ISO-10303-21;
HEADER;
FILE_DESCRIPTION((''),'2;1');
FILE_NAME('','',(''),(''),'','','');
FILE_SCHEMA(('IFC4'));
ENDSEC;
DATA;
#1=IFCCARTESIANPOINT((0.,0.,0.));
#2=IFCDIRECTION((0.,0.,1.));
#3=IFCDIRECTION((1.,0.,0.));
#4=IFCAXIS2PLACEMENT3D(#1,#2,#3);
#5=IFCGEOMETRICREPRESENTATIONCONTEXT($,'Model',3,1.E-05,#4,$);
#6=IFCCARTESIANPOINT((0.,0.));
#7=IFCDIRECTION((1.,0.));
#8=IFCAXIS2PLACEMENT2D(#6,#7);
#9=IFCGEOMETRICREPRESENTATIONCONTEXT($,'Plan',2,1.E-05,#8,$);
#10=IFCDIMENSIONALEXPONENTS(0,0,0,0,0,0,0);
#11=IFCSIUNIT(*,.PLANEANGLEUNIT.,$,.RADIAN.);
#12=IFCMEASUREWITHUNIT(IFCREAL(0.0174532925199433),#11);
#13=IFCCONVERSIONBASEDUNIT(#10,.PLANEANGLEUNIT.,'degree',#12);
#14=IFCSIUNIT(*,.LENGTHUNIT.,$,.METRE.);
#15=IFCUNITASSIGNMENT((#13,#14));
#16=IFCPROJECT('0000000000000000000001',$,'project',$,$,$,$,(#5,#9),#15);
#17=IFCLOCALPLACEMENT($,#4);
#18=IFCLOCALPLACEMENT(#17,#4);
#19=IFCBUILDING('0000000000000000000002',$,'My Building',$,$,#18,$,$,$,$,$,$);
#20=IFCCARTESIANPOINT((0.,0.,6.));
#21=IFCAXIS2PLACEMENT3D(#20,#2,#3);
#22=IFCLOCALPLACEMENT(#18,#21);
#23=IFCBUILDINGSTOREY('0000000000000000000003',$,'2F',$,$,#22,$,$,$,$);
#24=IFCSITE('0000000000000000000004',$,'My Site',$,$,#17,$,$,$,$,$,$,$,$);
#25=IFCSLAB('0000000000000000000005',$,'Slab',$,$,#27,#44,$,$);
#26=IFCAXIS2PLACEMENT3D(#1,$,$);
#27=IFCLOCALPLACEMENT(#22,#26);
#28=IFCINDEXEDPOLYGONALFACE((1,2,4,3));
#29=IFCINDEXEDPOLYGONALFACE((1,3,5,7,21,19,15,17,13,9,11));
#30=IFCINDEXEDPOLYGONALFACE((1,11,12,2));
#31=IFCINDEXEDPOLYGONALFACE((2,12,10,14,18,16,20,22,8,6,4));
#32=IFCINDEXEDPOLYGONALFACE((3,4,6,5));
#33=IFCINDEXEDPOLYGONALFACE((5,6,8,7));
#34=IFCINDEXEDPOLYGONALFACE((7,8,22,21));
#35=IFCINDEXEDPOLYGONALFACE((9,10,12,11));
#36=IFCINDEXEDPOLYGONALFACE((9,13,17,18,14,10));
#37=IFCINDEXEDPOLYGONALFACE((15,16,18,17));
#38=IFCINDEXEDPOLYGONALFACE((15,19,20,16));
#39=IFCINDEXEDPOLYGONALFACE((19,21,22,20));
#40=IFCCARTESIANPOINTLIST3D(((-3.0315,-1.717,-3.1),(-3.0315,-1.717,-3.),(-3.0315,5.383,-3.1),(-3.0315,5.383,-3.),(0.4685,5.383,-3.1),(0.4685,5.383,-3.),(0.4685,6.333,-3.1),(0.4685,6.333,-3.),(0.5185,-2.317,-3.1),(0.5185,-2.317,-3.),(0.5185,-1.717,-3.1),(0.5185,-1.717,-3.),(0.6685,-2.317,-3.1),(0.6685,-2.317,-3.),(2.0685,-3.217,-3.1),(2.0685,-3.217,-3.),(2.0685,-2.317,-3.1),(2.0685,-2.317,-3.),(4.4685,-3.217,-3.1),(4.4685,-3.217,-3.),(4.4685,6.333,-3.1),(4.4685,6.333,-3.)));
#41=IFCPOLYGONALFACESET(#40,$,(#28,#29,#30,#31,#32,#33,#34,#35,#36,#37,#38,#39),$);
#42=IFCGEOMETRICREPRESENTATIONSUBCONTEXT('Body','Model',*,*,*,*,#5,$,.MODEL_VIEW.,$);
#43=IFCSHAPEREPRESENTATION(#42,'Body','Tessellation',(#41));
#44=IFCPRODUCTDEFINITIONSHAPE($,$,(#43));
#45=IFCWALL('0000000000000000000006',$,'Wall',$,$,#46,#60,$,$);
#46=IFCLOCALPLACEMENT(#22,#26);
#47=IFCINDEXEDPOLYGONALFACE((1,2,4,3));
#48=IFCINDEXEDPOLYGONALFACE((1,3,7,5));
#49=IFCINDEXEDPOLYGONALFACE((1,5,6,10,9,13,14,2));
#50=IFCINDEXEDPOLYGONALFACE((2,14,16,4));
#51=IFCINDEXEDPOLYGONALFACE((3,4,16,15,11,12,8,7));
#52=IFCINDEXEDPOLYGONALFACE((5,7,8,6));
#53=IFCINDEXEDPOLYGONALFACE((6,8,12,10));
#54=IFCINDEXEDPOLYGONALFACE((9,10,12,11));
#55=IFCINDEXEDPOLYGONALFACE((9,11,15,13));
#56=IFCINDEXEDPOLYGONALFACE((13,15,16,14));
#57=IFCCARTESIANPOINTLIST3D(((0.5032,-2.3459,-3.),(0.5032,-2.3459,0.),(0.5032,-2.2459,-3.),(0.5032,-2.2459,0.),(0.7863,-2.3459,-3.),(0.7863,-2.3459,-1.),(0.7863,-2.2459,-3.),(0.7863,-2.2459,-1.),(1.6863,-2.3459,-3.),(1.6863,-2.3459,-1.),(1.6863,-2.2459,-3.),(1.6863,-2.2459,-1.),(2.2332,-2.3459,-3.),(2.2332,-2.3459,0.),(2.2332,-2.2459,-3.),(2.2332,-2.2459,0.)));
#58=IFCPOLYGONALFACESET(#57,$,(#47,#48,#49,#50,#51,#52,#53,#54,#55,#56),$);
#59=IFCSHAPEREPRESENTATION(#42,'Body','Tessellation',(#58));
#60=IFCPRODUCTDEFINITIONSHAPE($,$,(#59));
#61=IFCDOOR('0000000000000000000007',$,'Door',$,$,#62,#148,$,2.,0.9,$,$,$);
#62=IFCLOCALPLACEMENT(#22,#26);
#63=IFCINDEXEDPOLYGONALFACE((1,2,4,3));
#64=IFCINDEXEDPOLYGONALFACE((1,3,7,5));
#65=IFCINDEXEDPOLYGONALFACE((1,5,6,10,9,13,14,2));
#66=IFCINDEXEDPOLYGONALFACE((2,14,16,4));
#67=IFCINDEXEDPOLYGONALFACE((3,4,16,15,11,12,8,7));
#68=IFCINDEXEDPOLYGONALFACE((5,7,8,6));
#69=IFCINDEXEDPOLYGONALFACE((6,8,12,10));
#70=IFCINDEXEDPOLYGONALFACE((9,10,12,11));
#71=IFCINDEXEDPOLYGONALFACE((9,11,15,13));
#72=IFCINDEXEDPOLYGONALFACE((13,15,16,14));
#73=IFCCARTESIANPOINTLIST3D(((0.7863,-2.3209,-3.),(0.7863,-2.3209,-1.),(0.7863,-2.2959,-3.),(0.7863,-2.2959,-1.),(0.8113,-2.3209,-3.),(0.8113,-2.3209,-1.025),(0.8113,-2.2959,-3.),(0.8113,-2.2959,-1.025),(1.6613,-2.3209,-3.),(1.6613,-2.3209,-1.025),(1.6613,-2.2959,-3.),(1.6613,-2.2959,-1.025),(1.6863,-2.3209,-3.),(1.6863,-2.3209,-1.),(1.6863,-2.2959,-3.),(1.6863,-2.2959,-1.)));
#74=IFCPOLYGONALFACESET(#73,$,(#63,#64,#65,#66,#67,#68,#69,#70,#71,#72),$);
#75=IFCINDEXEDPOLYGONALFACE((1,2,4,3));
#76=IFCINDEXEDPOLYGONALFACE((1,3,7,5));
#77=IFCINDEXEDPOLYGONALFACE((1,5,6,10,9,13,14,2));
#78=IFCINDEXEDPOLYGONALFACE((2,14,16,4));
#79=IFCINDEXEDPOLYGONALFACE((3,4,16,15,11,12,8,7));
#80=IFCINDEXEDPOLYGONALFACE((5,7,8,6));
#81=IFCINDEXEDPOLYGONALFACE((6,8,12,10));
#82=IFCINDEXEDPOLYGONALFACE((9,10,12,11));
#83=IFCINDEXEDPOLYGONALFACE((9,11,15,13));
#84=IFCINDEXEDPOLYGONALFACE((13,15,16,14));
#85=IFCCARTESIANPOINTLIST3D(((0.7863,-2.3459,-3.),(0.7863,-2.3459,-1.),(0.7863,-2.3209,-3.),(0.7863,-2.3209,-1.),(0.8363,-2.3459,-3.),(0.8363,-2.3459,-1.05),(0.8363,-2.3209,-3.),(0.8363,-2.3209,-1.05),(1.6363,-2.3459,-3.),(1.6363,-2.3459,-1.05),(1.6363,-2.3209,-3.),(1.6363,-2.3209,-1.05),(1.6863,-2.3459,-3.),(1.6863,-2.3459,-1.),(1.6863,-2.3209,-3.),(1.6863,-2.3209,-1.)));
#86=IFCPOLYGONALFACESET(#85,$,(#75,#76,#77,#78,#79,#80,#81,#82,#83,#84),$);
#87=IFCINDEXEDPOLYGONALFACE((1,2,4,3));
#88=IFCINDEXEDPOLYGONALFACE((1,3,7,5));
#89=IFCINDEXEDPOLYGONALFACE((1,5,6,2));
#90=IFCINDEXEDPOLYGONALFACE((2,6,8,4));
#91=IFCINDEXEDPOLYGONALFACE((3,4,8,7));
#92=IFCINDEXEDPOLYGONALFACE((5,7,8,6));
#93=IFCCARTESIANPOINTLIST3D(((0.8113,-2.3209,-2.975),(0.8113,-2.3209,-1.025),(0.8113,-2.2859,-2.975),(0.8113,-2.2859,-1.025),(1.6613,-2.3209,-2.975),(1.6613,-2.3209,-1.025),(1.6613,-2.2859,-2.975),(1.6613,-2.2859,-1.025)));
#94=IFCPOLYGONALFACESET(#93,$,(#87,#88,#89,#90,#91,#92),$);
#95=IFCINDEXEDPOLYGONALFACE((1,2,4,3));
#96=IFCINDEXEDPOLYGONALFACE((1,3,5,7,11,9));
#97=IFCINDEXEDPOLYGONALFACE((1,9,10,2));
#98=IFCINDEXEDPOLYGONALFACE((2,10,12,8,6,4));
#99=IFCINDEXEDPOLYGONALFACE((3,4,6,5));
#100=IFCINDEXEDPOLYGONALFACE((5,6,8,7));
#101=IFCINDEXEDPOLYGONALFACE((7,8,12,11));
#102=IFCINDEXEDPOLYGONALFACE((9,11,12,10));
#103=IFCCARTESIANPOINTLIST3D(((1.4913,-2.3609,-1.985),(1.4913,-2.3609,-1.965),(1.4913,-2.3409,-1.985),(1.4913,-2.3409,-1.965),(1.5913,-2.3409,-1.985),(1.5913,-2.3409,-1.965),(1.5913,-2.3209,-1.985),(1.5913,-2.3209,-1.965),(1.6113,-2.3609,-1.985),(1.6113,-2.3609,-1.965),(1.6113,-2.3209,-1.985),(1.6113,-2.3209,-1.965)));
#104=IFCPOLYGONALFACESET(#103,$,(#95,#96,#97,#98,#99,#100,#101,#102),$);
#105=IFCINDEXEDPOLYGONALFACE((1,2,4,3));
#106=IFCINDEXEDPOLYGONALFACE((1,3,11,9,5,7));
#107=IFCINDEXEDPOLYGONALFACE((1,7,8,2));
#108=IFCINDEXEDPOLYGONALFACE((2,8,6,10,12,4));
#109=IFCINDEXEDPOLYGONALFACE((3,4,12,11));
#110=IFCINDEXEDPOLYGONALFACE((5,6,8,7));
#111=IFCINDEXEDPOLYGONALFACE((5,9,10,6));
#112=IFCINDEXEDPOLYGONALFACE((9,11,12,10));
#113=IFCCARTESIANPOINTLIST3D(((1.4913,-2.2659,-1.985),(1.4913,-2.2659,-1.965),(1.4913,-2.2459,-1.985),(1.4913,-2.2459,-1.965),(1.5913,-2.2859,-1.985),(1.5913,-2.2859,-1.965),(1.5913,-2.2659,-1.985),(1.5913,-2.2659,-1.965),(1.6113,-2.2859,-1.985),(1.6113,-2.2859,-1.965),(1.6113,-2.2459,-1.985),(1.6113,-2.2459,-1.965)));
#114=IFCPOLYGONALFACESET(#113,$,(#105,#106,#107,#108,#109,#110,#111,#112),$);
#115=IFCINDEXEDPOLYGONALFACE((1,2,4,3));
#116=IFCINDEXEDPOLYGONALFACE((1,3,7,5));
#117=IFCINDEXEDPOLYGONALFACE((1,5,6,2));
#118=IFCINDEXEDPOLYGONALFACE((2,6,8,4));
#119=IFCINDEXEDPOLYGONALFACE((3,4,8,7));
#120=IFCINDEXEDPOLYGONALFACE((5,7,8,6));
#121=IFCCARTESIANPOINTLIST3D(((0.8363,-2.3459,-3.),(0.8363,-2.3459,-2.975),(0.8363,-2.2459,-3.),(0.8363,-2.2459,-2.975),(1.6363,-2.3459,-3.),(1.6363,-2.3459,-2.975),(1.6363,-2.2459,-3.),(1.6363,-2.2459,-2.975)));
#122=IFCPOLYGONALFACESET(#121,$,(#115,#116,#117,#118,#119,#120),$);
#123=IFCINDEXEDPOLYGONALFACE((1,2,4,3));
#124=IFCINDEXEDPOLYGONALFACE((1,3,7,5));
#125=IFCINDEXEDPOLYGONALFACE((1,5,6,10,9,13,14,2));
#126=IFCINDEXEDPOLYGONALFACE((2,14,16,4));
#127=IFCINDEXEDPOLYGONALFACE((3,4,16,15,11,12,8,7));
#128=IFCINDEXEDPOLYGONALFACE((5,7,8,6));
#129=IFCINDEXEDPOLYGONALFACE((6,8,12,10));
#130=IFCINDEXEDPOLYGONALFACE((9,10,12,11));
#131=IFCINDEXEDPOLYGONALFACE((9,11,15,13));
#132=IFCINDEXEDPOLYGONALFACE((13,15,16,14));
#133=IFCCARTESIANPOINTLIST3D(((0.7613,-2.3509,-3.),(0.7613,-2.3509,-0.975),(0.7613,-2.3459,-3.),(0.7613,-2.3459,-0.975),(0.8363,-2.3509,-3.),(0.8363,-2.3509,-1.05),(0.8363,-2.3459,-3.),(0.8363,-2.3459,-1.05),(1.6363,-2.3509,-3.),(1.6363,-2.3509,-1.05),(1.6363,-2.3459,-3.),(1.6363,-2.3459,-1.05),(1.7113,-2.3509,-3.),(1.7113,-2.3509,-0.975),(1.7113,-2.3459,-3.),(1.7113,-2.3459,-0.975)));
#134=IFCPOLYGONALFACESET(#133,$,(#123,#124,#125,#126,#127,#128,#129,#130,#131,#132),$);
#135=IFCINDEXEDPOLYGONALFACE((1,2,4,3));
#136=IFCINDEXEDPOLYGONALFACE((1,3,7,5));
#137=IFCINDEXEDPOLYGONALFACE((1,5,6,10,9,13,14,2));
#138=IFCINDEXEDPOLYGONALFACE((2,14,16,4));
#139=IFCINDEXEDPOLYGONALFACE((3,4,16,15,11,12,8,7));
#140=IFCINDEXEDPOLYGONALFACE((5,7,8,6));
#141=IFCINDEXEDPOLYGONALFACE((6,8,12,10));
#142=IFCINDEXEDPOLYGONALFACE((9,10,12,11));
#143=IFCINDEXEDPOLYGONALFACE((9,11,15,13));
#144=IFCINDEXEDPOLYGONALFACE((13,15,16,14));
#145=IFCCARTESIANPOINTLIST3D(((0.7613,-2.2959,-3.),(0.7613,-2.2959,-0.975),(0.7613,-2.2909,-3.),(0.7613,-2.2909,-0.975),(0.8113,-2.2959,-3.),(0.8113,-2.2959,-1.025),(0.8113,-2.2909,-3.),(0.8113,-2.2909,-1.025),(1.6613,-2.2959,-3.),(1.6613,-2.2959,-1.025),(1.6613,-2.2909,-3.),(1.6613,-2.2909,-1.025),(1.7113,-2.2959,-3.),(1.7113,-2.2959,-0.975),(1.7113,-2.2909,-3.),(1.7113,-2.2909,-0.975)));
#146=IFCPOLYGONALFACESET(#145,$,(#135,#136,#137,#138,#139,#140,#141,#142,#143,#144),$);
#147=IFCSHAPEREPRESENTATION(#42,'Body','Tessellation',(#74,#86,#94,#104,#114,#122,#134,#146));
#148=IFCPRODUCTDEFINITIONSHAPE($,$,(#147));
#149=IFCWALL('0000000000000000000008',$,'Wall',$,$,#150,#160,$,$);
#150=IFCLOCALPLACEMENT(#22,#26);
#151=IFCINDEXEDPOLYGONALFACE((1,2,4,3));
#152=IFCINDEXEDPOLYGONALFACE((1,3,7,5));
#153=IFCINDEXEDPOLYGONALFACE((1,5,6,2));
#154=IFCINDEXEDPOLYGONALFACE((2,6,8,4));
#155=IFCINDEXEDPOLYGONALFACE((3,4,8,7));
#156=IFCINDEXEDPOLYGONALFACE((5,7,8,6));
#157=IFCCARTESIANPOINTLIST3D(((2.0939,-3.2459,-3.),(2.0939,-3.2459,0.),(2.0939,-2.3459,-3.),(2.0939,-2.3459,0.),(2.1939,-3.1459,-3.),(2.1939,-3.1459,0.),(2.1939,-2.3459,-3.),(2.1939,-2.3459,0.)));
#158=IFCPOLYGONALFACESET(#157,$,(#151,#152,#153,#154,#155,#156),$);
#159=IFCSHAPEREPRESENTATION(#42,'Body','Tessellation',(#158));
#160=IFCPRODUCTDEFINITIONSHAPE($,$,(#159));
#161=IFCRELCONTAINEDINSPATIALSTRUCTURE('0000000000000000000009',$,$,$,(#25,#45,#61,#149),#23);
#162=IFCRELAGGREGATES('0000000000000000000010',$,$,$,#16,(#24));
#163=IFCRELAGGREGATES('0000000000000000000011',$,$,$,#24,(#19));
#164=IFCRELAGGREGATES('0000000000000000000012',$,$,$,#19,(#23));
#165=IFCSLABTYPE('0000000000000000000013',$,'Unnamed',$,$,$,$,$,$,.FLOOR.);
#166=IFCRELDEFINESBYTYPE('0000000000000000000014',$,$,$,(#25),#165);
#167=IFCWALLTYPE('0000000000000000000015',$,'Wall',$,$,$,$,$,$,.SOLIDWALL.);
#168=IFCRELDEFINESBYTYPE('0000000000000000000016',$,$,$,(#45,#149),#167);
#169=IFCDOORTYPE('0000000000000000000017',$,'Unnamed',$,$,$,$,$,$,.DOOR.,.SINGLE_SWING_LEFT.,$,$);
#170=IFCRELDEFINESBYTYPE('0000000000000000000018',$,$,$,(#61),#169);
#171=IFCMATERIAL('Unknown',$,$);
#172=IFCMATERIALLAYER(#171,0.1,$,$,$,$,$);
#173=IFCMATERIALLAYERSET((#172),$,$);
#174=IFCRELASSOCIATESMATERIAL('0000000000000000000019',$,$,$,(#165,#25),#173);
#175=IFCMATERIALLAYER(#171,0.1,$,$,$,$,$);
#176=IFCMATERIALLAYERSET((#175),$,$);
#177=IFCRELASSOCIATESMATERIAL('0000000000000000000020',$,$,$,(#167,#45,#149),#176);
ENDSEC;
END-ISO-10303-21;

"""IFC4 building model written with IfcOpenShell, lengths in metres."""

from ifc_helpers import new_model, entity, si_unit, converted_unit, frame, origin_with_axes, origin_2d_with_axis, place, context, subcontext, project, spatial, line, indexed_curve, outline, extrude, shape, source, transform, mapped, material, layer, layer_set, layer_usage, type_object, type_shapes, element, fill, save


model = new_model("IFC4")

# Units and contexts
model_context = context("Model", 3, precision=1e-05, world=origin_with_axes())
plan_context = context("Plan", 2, precision=1e-05, world=origin_2d_with_axis())
body_context_1 = subcontext(model_context, "Body", "Model", "MODEL_VIEW")
body_context_2 = subcontext(plan_context, "Body", "Plan", "PLAN_VIEW")
ifc_project = project(units=[converted_unit("PLANEANGLEUNIT", "degree", entity("IfcReal", 0.0174532925199433), si_unit("PLANEANGLEUNIT", "RADIAN"), dimensions=[0, 0, 0, 0, 0, 0, 0]), si_unit("LENGTHUNIT", "METRE")], contexts=[model_context, plan_context])

# Site, building, storey
site_placement = place(None, origin_with_axes())
site = spatial("IfcSite", under=ifc_project, at=site_placement, Name="My Site")
building_placement = place(site_placement, origin_with_axes())
building = spatial("IfcBuilding", under=site, at=building_placement, Name="My Building")
storey_placement = place(building_placement, frame((0.0, 0.0, 6.0), z_axis=(0.0, 0.0, 1.0), x_axis=(1.0, 0.0, 0.0)))
storey = spatial("IfcBuildingStorey", under=building, at=storey_placement, Name="2F")

# Slab
ifc_material = material(Name="Unknown")
ifc_layer_1 = layer(ifc_material, 0.1)
ifc_layer_set_1 = layer_set([ifc_layer_1])
ifc_layer_usage_1 = layer_usage(ifc_layer_set_1, "AXIS3", "POSITIVE", -0.1)
slab_type = type_object("IfcSlabType", Name="Unnamed", PredefinedType="FLOOR", material=ifc_layer_set_1)
slab_placement = place(storey_placement, frame((0.6685, -2.317, -3.0), z_axis=(0.0, 0.0, 1.0), x_axis=(1.0, 0.0, 0.0)))
element("IfcSlab", 1, at=slab_placement, inside=storey, type_object=slab_type, material=ifc_layer_usage_1, Name="Slab", context=body_context_1, shape_type="SweptSolid", body=[
    extrude(outline(indexed_curve([(0.0, 0.0), (1.4, 0.0), (1.4, -0.9), (3.8, -0.9), (3.8, 8.65), (-0.2, 8.65), (-0.2, 7.7), (-3.7, 7.7), (-3.7, 0.6), (-0.15, 0.6), (-0.15, 0.0), (0.0, 0.0)])), frame((0.0, 0.0, -0.1), z_axis=(0.0, 0.0, 1.0), x_axis=(1.0, 0.0, 0.0)), (0.0, 0.0, 1.0), 0.1),
])

# Wall, opening, door
ifc_layer_2 = layer(ifc_material, 0.1)
ifc_layer_set_2 = layer_set([ifc_layer_2])
ifc_layer_usage_2 = layer_usage(ifc_layer_set_2, "AXIS2", "POSITIVE", 0.0)
wall_type = type_object("IfcWallType", Name="Wall", PredefinedType="SOLIDWALL", material=ifc_layer_set_2)
wall_1_placement = place(storey_placement, frame((0.5032, -2.3459, -3.0), z_axis=(0.0, 0.0, 1.0), x_axis=(1.0, 0.0, 0.0)))
wall_1 = element("IfcWall", 2, at=wall_1_placement, inside=storey, type_object=wall_type, material=ifc_layer_usage_2, Name="Wall", context=body_context_1, shape_type="SweptSolid", body=[
    extrude(outline(indexed_curve([(0.0, 0.0), (0.0, 0.1), (1.73, 0.1), (1.73, 0.0)], segments=[line(1, 2, 3, 4, 1)])), origin_with_axes(), (0.0, 0.0, 1.0), 3.0),
])
shared_shape_1 = source(origin_with_axes(), body_context_1, "Body", "SweptSolid", [
    extrude(outline(indexed_curve([(0.0, 0.0), (0.9, 0.0), (0.9, 2.0), (0.0, 2.0)], segments=[line(1, 2, 3, 4, 1)])), frame((0.0, -0.6, 0.0), z_axis=(0.0, -1.0, 0.0), x_axis=(1.0, 0.0, 0.0)), (0.0, 0.0, -1.0), 1.2),
])
opening_1_placement = place(wall_1_placement, frame((0.2831, 0.0, 0.0), z_axis=(0.0, 0.0, 1.0), x_axis=(1.0, 0.0, 0.0)))
opening_1 = element("IfcOpeningElement", 3, at=opening_1_placement, cuts=wall_1, PredefinedType="OPENING", context=body_context_1, shape_type="MappedRepresentation", body=[
    mapped(shared_shape_1, transform((0.0, 0.0, 0.0), x_axis=(1.0, 0.0, 0.0), y_axis=(0.0, 1.0, 0.0), z_axis=(0.0, 0.0, 1.0), scale=1.0)),
])
door_type = type_object("IfcDoorType", Name="Unnamed", OperationType="SINGLE_SWING_LEFT", PredefinedType="DOOR")
shared_shape_2 = source(origin_with_axes(), body_context_1, "Body", "SweptSolid", [
    extrude(outline(indexed_curve([(0.0, 0.0), (0.0, 2.0), (0.9, 2.0), (0.9, 0.0), (0.875, 0.0), (0.875, 1.975), (0.025, 1.975), (0.025, 0.0)], segments=[line(1, 2, 3, 4, 5, 6, 7, 8, 1)])), frame((0.0, 0.025, 0.0), z_axis=(0.0, -1.0, 0.0), x_axis=(1.0, 0.0, 0.0)), (0.0, 0.0, -1.0), 0.025),
    extrude(outline(indexed_curve([(0.0, 0.0), (0.0, 2.0), (0.9, 2.0), (0.9, 0.0), (0.85, 0.0), (0.85, 1.95), (0.05, 1.95), (0.05, 0.0)], segments=[line(1, 2, 3, 4, 5, 6, 7, 8, 1)])), frame((0.0, 0.0, 0.0), z_axis=(0.0, -1.0, 0.0), x_axis=(1.0, 0.0, 0.0)), (0.0, 0.0, -1.0), 0.025),
    extrude(outline(indexed_curve([(0.0, 0.0), (0.85, 0.0), (0.85, 0.035), (0.0, 0.035)], segments=[line(1, 2, 3, 4, 1)])), frame((0.025, 0.025, 0.025), z_axis=(0.0, 0.0, 1.0), x_axis=(1.0, 0.0, 0.0)), (0.0, 0.0, 1.0), 1.95),
    extrude(outline(indexed_curve([(0.0, 0.0), (0.0, -0.04), (-0.12, -0.04), (-0.12, -0.02), (-0.02, -0.02), (-0.02, 0.0)], segments=[line(1, 2, 3, 4, 5, 6, 1)])), frame((0.825, 0.025, 1.015), z_axis=(0.0, 0.0, 1.0), x_axis=(1.0, 0.0, 0.0)), (0.0, 0.0, 1.0), 0.02),
    extrude(outline(indexed_curve([(0.0, 0.0), (0.0, 0.04), (-0.12, 0.04), (-0.12, 0.02), (-0.02, 0.02), (-0.02, 0.0)], segments=[line(1, 2, 3, 4, 5, 6, 1)])), frame((0.825, 0.06, 1.015), z_axis=(0.0, 0.0, 1.0), x_axis=(1.0, 0.0, 0.0)), (0.0, 0.0, 1.0), 0.02),
    extrude(outline(indexed_curve([(0.0, 0.0), (0.8, 0.0), (0.8, 0.1), (0.0, 0.1)], segments=[line(1, 2, 3, 4, 1)])), frame((0.05, 0.0, 0.0), z_axis=(0.0, 0.0, 1.0), x_axis=(1.0, 0.0, 0.0)), (0.0, 0.0, 1.0), 0.025),
    extrude(outline(indexed_curve([(0.0, 0.0), (0.0, 2.025), (0.95, 2.025), (0.95, 0.0), (0.875, 0.0), (0.875, 1.95), (0.075, 1.95), (0.075, 0.0)], segments=[line(1, 2, 3, 4, 5, 6, 7, 8, 1)])), frame((-0.025, -0.005, 0.0), z_axis=(0.0, -1.0, 0.0), x_axis=(1.0, 0.0, 0.0)), (0.0, 0.0, -1.0), 0.005),
    extrude(outline(indexed_curve([(0.0, 0.0), (0.0, 2.025), (0.95, 2.025), (0.95, 0.0), (0.9, 0.0), (0.9, 1.975), (0.05, 1.975), (0.05, 0.0)], segments=[line(1, 2, 3, 4, 5, 6, 7, 8, 1)])), frame((-0.025, 0.05, 0.0), z_axis=(0.0, -1.0, 0.0), x_axis=(1.0, 0.0, 0.0)), (0.0, 0.0, -1.0), 0.005),
])
shared_shape_3 = source(origin_with_axes(), body_context_2, "Body", "Curve2D", [
    entity("IfcIndexedPolyCurve", entity("IfcCartesianPointList2D", [[0.0, 0.0], [0.0, 0.05], [0.025, 0.05], [0.025, 0.025], [0.05, 0.025], [0.05, 0.0]]), [entity("IfcLineIndex", [1, 2, 3, 4, 5, 6, 1])]),
    entity("IfcIndexedPolyCurve", entity("IfcCartesianPointList2D", [[0.9, 0.0], [0.9, 0.05], [0.875, 0.05], [0.875, 0.025], [0.85, 0.025], [0.85, 0.0]]), [entity("IfcLineIndex", [1, 2, 3, 4, 5, 6, 1])]),
    entity("IfcTrimmedCurve", entity("IfcEllipse", entity("IfcAxis2Placement2D", entity("IfcCartesianPoint", [0.06, 0.05]), entity("IfcDirection", [1.0, 0.0])), 0.815, 0.85), [entity("IfcCartesianPoint", [0.875, 0.05])], [entity("IfcCartesianPoint", [0.06, 0.9])], True, "CARTESIAN"),
    entity("IfcIndexedPolyCurve", entity("IfcCartesianPointList2D", [[0.025, 0.05], [0.06, 0.05], [0.06, 0.9], [0.025, 0.9]]), [entity("IfcLineIndex", [1, 2, 3, 4, 1])]),
])
type_shapes(door_type, [shared_shape_2, shared_shape_3])
door_1_placement = place(opening_1_placement, origin_with_axes())
door_1 = element("IfcDoor", 4, at=door_1_placement, inside=storey, type_object=door_type, Name="Door", OverallHeight=2.0, OverallWidth=0.9, shapes=[
    shape(body_context_1, "Body", "MappedRepresentation", [mapped(shared_shape_2, transform((0.0, 0.0, 0.0), x_axis=(1.0, 0.0, 0.0), y_axis=(0.0, 1.0, 0.0), z_axis=(0.0, 0.0, 1.0), scale=1.0))]),
    shape(body_context_2, "Body", "MappedRepresentation", [mapped(shared_shape_3, transform((0.0, 0.0, 0.0), x_axis=(1.0, 0.0, 0.0), y_axis=(0.0, 1.0, 0.0), z_axis=(0.0, 0.0, 1.0), scale=1.0))]),
])
fill(opening_1, door_1)

# Wall
ifc_layer_usage_3 = layer_usage(ifc_layer_set_2, "AXIS2", "POSITIVE", 0.0)
wall_2_placement = place(storey_placement, frame((2.0939, -2.3459, -3.0), z_axis=(0.0, 0.0, 1.0), x_axis=(0.0, -1.0, 0.0)))
element("IfcWall", 5, at=wall_2_placement, inside=storey, type_object=wall_type, material=ifc_layer_usage_3, Name="Wall", context=body_context_1, shape_type="SweptSolid", body=[
    extrude(outline(indexed_curve([(0.0, 0.0), (0.0, 0.1), (0.8, 0.1), (0.9, 0.0)], segments=[line(1, 2, 3, 4, 1)])), origin_with_axes(), (0.0, 0.0, 1.0), 3.0),
])

save(model, "model.ifc")
